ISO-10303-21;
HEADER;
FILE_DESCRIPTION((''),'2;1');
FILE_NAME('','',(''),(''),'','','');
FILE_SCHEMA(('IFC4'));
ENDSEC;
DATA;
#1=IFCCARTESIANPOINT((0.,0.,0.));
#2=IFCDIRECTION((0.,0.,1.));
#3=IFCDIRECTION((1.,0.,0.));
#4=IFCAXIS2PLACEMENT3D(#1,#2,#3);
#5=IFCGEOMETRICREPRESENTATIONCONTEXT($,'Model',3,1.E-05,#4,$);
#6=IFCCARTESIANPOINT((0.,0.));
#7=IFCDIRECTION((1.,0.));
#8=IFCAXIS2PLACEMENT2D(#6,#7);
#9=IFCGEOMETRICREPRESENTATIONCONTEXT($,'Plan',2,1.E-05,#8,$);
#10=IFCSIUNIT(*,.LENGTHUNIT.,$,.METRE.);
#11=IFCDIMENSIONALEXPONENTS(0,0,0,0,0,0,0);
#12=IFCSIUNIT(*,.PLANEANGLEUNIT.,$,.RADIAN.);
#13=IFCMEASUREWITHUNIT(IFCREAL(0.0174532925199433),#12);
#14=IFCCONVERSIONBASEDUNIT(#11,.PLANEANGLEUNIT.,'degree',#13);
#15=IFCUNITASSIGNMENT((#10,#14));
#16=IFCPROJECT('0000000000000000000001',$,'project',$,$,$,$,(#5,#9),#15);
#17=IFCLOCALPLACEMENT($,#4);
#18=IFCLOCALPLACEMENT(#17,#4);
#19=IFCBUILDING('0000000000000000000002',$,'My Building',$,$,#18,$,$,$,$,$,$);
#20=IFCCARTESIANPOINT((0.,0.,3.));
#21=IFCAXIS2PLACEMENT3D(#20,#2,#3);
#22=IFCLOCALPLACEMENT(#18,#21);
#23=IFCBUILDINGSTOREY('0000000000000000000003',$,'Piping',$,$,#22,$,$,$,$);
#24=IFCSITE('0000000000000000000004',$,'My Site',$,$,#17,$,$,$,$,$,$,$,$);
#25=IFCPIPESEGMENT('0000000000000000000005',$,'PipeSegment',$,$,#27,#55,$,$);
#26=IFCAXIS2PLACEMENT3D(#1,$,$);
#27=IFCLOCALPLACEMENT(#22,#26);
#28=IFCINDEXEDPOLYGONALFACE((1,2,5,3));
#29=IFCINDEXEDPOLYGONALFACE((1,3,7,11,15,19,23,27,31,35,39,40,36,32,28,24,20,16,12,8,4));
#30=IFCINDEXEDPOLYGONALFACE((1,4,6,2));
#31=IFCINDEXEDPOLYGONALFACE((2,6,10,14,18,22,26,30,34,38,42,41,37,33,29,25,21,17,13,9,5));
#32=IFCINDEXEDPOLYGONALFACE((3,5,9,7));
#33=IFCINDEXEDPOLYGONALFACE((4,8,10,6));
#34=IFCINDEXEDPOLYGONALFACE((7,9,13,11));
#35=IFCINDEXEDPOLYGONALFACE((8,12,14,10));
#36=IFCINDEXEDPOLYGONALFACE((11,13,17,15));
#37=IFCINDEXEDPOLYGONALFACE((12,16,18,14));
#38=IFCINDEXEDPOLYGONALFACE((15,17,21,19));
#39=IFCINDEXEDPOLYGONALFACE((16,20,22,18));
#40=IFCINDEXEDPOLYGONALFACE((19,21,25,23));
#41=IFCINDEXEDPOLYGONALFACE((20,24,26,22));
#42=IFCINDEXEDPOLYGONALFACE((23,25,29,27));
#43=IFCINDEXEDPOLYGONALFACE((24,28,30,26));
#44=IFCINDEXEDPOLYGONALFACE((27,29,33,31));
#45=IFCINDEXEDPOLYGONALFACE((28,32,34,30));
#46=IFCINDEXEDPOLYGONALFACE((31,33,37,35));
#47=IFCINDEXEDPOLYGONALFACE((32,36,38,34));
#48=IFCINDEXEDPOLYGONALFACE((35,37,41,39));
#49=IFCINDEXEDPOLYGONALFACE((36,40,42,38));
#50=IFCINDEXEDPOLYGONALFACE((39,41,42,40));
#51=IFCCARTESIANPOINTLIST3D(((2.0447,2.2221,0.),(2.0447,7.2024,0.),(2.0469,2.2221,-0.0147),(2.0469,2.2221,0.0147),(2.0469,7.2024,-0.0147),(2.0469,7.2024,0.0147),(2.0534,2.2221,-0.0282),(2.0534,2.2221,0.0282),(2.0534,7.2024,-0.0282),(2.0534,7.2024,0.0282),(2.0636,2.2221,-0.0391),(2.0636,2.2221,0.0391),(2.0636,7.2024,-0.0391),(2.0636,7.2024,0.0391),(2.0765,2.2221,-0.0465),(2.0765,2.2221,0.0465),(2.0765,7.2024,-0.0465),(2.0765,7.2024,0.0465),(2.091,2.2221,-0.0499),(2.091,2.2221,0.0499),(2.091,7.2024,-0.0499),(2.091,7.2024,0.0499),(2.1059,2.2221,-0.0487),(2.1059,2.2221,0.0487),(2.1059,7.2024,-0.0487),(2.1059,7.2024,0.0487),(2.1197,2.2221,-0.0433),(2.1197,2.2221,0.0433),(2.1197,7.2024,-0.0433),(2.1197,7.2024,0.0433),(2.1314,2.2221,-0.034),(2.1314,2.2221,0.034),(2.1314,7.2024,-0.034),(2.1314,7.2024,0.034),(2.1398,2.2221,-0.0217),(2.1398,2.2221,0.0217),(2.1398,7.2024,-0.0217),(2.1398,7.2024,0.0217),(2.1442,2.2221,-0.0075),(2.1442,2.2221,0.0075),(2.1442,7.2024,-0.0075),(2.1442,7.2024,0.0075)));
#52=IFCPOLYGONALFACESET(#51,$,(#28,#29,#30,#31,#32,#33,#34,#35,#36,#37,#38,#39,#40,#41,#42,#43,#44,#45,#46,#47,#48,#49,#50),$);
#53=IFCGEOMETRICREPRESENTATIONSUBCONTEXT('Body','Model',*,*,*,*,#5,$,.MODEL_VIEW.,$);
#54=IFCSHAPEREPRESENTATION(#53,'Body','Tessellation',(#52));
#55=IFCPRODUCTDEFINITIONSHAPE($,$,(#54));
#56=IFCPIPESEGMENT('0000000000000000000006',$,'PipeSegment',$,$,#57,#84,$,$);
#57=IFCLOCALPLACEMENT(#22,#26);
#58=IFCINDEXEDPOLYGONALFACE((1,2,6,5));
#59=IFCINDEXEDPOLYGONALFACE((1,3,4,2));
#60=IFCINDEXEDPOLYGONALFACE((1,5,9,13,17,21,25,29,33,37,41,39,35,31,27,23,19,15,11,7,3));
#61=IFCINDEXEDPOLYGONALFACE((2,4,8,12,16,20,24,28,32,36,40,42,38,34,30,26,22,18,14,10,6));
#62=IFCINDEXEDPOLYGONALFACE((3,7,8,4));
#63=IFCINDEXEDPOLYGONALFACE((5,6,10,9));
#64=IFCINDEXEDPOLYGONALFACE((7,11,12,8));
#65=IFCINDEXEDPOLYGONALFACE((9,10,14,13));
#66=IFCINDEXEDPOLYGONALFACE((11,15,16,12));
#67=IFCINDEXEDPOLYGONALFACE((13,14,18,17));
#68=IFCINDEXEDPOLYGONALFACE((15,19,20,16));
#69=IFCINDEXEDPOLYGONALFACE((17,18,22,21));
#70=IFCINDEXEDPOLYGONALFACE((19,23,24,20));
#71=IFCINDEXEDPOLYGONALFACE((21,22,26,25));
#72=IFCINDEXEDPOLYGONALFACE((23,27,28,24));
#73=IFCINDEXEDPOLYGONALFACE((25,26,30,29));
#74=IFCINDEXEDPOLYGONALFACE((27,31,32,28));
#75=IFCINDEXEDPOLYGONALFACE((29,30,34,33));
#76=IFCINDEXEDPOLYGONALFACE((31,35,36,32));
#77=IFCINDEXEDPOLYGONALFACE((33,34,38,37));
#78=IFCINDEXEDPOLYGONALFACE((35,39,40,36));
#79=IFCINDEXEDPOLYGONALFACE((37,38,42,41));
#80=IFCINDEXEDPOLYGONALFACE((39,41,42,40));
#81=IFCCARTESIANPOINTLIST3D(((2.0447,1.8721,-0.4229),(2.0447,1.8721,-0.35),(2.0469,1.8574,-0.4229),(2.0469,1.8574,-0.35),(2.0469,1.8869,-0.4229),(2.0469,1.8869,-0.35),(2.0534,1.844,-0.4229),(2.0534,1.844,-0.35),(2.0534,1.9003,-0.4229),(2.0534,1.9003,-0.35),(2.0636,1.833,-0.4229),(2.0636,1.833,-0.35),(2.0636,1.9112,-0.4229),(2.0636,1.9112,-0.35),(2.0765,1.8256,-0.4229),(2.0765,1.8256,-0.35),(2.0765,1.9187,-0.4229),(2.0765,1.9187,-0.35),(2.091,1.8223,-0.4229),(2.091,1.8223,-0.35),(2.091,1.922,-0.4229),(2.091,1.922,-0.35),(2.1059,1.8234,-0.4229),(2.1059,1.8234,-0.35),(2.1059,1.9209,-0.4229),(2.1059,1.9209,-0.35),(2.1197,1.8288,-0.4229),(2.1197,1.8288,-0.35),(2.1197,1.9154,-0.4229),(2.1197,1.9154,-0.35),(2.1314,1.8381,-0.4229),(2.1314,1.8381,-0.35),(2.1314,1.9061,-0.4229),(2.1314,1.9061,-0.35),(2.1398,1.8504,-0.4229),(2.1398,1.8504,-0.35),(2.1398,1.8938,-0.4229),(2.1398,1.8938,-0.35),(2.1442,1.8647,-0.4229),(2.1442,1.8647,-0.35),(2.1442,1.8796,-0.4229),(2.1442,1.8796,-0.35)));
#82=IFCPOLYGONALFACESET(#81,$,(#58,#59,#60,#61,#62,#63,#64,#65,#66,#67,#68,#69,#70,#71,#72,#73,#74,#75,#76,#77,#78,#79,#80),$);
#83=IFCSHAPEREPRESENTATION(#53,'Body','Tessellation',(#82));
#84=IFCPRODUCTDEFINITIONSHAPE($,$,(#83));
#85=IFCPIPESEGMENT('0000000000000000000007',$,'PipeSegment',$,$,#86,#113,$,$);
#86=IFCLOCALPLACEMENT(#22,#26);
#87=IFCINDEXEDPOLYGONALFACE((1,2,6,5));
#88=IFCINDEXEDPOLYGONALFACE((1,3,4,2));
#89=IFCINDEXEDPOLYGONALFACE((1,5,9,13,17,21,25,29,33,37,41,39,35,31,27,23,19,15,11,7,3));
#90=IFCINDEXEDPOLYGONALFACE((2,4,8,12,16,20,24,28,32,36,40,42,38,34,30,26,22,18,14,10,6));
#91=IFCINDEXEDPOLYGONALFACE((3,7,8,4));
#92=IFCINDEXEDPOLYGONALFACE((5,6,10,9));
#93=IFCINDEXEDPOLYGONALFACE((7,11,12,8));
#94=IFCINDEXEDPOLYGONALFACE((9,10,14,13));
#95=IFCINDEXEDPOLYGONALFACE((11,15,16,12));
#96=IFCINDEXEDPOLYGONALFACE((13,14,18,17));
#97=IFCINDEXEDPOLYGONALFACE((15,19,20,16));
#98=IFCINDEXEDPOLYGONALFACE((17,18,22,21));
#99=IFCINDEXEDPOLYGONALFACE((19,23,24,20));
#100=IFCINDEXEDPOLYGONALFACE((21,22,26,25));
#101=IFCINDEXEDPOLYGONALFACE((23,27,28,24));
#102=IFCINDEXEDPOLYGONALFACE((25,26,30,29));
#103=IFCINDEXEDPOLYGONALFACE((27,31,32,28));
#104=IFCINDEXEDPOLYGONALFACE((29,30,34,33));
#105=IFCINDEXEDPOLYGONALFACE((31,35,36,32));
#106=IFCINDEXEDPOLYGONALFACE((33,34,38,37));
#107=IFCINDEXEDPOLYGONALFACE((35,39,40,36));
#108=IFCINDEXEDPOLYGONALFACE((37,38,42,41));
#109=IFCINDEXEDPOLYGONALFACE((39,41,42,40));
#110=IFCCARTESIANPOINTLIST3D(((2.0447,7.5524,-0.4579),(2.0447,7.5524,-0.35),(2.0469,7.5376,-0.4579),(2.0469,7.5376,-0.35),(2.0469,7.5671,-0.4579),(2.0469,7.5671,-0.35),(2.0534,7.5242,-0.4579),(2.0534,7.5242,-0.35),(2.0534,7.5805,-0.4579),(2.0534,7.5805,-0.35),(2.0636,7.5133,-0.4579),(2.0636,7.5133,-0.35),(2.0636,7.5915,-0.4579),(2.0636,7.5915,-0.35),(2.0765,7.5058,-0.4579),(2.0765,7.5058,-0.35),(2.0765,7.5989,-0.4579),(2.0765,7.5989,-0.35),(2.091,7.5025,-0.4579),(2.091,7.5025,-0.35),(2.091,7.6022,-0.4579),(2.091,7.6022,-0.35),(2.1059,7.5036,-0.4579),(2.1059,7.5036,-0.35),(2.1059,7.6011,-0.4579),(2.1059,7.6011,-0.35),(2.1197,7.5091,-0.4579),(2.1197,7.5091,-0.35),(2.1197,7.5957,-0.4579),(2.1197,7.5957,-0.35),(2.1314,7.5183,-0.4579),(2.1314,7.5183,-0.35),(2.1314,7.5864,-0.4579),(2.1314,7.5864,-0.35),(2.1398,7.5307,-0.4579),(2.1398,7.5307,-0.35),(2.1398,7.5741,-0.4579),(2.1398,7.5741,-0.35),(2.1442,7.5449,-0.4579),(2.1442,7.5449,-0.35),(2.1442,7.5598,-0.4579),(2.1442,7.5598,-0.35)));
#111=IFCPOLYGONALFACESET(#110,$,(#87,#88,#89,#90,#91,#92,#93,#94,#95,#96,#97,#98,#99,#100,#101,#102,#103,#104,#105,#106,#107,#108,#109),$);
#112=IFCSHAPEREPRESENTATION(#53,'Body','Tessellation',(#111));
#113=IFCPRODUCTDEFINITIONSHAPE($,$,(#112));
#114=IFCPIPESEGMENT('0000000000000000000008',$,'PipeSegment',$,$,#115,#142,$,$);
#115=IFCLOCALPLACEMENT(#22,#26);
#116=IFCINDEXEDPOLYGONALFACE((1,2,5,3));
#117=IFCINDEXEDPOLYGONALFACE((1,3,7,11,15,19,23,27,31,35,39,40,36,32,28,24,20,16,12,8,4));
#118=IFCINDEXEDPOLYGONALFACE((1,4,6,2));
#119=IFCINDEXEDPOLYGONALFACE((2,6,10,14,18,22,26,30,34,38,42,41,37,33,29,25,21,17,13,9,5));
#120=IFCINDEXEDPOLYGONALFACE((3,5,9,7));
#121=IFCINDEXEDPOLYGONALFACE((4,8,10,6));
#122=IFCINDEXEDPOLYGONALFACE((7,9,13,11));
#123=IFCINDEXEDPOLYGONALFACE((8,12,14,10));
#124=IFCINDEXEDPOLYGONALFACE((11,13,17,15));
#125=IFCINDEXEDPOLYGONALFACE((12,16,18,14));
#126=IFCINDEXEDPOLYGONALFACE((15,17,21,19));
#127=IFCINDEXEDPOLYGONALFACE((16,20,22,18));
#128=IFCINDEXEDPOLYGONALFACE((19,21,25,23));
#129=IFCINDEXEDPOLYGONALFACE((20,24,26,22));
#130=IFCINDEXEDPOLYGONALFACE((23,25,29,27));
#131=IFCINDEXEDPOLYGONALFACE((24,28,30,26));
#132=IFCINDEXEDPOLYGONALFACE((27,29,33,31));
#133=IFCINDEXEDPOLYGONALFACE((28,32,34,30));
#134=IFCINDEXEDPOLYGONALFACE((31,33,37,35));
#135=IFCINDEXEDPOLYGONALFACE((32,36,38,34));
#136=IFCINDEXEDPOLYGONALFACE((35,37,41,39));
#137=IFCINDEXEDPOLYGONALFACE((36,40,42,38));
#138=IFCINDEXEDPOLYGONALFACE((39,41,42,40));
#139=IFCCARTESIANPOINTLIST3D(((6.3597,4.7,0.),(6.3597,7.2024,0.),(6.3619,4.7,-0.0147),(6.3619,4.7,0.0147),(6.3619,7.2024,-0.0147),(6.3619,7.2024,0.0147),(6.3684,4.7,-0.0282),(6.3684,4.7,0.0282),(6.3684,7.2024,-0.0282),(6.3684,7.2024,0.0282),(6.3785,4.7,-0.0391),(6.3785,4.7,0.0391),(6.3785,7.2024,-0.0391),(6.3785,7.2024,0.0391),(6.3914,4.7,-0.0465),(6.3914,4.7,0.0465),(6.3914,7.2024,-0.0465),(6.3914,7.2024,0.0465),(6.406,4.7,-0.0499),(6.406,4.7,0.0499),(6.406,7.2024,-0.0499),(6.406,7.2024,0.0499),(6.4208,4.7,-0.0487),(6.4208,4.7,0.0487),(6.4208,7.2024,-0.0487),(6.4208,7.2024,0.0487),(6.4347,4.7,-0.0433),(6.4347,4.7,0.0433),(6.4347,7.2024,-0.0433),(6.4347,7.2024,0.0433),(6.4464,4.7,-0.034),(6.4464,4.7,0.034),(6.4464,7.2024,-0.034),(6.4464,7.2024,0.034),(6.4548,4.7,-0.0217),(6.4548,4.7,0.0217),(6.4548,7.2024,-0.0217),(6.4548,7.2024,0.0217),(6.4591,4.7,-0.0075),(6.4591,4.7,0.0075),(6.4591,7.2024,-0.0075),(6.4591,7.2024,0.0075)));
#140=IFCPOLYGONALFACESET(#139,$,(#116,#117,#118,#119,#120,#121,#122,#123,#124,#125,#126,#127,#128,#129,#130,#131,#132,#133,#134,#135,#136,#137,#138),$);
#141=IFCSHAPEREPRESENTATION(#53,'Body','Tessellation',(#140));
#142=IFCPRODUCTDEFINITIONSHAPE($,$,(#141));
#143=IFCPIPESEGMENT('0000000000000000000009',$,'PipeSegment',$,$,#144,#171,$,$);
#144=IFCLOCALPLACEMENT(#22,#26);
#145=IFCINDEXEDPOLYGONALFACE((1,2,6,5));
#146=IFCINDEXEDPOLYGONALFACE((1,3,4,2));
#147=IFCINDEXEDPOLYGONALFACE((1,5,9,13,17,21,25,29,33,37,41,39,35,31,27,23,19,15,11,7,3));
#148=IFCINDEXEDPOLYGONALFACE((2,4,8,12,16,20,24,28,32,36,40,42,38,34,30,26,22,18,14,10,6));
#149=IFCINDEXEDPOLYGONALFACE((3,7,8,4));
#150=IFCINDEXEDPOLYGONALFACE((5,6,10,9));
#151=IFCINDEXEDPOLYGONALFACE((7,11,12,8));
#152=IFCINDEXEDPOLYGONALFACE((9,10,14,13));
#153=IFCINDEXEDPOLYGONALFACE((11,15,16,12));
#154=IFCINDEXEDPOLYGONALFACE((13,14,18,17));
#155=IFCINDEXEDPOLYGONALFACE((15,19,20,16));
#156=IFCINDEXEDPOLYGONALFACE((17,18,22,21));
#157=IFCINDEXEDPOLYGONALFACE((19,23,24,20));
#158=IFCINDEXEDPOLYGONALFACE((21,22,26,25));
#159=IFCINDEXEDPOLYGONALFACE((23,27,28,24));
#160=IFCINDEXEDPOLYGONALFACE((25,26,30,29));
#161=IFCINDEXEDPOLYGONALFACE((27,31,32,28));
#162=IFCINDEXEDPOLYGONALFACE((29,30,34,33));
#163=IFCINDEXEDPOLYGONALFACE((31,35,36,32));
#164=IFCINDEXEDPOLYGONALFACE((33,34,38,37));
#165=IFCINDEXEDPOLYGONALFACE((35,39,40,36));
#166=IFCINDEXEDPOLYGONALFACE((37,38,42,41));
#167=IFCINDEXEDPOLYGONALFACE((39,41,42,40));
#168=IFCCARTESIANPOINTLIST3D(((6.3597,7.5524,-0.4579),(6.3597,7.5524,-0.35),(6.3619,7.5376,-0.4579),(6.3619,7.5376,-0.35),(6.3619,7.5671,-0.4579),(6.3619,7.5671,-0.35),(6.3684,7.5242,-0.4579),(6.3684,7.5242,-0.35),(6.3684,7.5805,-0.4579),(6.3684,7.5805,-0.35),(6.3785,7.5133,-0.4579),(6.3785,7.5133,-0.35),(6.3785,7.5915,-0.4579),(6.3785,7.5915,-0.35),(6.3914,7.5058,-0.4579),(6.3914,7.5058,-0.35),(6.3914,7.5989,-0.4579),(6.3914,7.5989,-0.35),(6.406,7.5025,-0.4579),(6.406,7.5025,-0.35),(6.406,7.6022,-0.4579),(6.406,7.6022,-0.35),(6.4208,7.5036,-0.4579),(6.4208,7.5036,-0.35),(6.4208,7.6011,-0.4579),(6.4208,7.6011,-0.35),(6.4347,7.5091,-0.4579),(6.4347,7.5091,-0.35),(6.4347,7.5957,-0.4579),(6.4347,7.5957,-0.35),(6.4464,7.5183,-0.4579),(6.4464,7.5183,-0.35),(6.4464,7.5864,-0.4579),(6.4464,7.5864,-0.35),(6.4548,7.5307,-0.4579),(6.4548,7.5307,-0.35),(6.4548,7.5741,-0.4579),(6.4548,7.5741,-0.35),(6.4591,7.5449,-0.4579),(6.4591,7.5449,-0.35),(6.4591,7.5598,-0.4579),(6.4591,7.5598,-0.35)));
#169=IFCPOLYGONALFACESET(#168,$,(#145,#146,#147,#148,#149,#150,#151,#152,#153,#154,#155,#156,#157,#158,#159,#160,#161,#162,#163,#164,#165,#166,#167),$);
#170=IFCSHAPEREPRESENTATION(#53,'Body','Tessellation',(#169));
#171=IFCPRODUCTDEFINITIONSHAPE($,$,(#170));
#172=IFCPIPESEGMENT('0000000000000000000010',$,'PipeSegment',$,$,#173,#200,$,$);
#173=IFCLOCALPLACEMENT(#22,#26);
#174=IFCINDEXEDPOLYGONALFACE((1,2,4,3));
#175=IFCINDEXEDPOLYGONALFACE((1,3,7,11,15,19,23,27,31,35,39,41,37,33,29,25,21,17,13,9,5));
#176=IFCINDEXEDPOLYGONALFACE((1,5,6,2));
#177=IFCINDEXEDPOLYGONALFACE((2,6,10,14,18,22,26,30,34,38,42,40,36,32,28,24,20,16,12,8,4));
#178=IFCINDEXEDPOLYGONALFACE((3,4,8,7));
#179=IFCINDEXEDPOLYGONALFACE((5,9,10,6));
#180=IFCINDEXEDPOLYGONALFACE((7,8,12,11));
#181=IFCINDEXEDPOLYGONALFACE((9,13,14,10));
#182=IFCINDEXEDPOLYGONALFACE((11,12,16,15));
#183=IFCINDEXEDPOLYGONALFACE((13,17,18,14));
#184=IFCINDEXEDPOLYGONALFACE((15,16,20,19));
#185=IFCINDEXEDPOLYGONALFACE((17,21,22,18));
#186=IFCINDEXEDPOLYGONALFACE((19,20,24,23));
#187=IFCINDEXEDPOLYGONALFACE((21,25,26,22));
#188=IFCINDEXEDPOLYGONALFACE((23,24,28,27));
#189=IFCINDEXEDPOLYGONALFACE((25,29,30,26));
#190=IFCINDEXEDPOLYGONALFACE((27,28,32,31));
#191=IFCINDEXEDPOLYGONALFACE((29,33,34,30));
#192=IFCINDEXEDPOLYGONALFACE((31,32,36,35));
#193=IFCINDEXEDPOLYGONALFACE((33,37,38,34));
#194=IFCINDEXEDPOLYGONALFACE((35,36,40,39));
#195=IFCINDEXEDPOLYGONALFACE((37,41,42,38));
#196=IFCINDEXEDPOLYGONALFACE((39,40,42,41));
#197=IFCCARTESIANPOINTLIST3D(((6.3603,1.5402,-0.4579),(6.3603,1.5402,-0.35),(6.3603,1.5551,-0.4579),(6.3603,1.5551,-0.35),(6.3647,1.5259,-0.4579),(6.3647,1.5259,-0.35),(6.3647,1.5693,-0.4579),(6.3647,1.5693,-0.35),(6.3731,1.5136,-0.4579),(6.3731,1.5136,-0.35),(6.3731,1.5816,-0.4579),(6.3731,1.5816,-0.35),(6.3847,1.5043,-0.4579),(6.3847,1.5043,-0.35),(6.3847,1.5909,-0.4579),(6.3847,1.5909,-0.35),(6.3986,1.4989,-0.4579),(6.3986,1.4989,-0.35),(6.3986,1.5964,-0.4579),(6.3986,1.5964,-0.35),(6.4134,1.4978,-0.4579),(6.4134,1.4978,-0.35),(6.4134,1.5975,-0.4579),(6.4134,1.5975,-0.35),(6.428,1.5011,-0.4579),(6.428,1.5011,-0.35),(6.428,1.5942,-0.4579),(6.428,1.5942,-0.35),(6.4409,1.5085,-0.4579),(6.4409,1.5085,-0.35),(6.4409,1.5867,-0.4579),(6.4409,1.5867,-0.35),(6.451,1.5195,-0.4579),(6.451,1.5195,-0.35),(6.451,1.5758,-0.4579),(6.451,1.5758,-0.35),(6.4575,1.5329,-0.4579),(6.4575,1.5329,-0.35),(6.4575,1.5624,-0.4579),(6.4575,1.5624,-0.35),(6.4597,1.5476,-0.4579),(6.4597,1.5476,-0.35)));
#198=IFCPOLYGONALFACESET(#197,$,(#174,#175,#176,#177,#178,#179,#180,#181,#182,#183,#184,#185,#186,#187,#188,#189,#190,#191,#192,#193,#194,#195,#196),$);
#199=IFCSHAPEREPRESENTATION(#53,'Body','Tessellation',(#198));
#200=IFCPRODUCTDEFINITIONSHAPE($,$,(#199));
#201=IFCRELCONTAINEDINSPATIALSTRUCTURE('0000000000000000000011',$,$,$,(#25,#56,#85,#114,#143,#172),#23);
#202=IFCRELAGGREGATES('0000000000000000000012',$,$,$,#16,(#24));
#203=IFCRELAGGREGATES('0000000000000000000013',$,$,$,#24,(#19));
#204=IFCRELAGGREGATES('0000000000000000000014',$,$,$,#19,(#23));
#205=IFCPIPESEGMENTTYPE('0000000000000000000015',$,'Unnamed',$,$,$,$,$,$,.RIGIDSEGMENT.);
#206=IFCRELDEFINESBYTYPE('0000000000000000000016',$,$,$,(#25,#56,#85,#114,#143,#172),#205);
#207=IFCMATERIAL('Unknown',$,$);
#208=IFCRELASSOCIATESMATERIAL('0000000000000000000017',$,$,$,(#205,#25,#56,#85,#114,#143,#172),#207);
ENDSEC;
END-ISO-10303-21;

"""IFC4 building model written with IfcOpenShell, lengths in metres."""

from ifc_helpers import new_model, entity, si_unit, converted_unit, frame, origin_with_axes, origin_2d_with_axis, place, context, subcontext, project, spatial, circle, extrude, material, material_profile, profile_set, profile_usage, type_object, element, save


model = new_model("IFC4")

# Units and contexts
model_context = context("Model", 3, precision=1e-05, world=origin_with_axes())
plan_context = context("Plan", 2, precision=1e-05, world=origin_2d_with_axis())
body_context = subcontext(model_context, "Body", "Model", "MODEL_VIEW")
ifc_project = project(units=[si_unit("LENGTHUNIT", "METRE"), converted_unit("PLANEANGLEUNIT", "degree", entity("IfcReal", 0.0174532925199433), si_unit("PLANEANGLEUNIT", "RADIAN"), dimensions=[0, 0, 0, 0, 0, 0, 0])], contexts=[model_context, plan_context])

# Site, building, storey
site_placement = place(None, origin_with_axes())
site = spatial("IfcSite", under=ifc_project, at=site_placement, Name="My Site")
building_placement = place(site_placement, origin_with_axes())
building = spatial("IfcBuilding", under=site, at=building_placement, Name="My Building")
storey_placement = place(building_placement, frame((0.0, 0.0, 3.0), z_axis=(0.0, 0.0, 1.0), x_axis=(1.0, 0.0, 0.0)))
storey = spatial("IfcBuildingStorey", under=building, at=storey_placement, Name="Piping")

# Pipe segments
ifc_material = material(Name="Unknown")
ifc_material_profile_1 = material_profile(ifc_material, circle(Radius=0.05))
ifc_profile_set_1 = profile_set([ifc_material_profile_1])
ifc_profile_usage_1 = profile_usage(ifc_profile_set_1, cardinal=5)
pipe_segment_type = type_object("IfcPipeSegmentType", Name="Unnamed", PredefinedType="RIGIDSEGMENT", material=ifc_profile_set_1)
pipe_segment_1_placement = place(storey_placement, frame((2.0947, 2.2221, 0.0), z_axis=(0.0, 1.0, 0.0), x_axis=(-1.0, 0.0, 0.0)))
element("IfcPipeSegment", 1, at=pipe_segment_1_placement, inside=storey, type_object=pipe_segment_type, material=ifc_profile_usage_1, Name="PipeSegment", context=body_context, shape_type="SweptSolid", body=[
    extrude(circle(Radius=0.05), origin_with_axes(), (0.0, 0.0, 1.0), 4.9802),
])
ifc_profile_usage_2 = profile_usage(ifc_profile_set_1, cardinal=5)
pipe_segment_2_placement = place(storey_placement, frame((2.0947, 1.8721, -0.35), z_axis=(0.0, 0.0, -1.0), x_axis=(-1.0, 0.0, 0.0)))
element("IfcPipeSegment", 2, at=pipe_segment_2_placement, inside=storey, type_object=pipe_segment_type, material=ifc_profile_usage_2, Name="PipeSegment", context=body_context, shape_type="SweptSolid", body=[
    extrude(circle(Radius=0.05), origin_with_axes(), (0.0, 0.0, 1.0), 0.0729),
])
ifc_profile_usage_3 = profile_usage(ifc_profile_set_1, cardinal=5)
pipe_segment_3_placement = place(storey_placement, frame((2.0947, 7.5524, -0.35), z_axis=(0.0, 0.0, -1.0), x_axis=(-1.0, 0.0, 0.0)))
element("IfcPipeSegment", 3, at=pipe_segment_3_placement, inside=storey, type_object=pipe_segment_type, material=ifc_profile_usage_3, Name="PipeSegment", context=body_context, shape_type="SweptSolid", body=[
    extrude(circle(Radius=0.05), origin_with_axes(), (0.0, 0.0, 1.0), 0.1079),
])
ifc_profile_usage_4 = profile_usage(ifc_profile_set_1, cardinal=5)
pipe_segment_4_placement = place(storey_placement, frame((6.4097, 4.7, 0.0), z_axis=(0.0, 1.0, 0.0), x_axis=(-1.0, 0.0, 0.0)))
element("IfcPipeSegment", 4, at=pipe_segment_4_placement, inside=storey, type_object=pipe_segment_type, material=ifc_profile_usage_4, Name="PipeSegment", context=body_context, shape_type="SweptSolid", body=[
    extrude(circle(Radius=0.05), origin_with_axes(), (0.0, 0.0, 1.0), 2.5024),
])
ifc_profile_usage_5 = profile_usage(ifc_profile_set_1, cardinal=5)
pipe_segment_5_placement = place(storey_placement, frame((6.4097, 7.5524, -0.35), z_axis=(0.0, 0.0, -1.0), x_axis=(-1.0, 0.0, 0.0)))
element("IfcPipeSegment", 5, at=pipe_segment_5_placement, inside=storey, type_object=pipe_segment_type, material=ifc_profile_usage_5, Name="PipeSegment", context=body_context, shape_type="SweptSolid", body=[
    extrude(circle(Radius=0.05), origin_with_axes(), (0.0, 0.0, 1.0), 0.1079),
])
ifc_profile_usage_6 = profile_usage(ifc_profile_set_1, cardinal=5)
pipe_segment_6_placement = place(storey_placement, frame((6.4097, 1.5476, -0.35), z_axis=(0.0, 0.0, -1.0), x_axis=(1.0, 0.0, 0.0)))
element("IfcPipeSegment", 6, at=pipe_segment_6_placement, inside=storey, type_object=pipe_segment_type, material=ifc_profile_usage_6, Name="PipeSegment", context=body_context, shape_type="SweptSolid", body=[
    extrude(circle(Radius=0.05), origin_with_axes(), (0.0, 0.0, 1.0), 0.1079),
])

save(model, "model.ifc")
